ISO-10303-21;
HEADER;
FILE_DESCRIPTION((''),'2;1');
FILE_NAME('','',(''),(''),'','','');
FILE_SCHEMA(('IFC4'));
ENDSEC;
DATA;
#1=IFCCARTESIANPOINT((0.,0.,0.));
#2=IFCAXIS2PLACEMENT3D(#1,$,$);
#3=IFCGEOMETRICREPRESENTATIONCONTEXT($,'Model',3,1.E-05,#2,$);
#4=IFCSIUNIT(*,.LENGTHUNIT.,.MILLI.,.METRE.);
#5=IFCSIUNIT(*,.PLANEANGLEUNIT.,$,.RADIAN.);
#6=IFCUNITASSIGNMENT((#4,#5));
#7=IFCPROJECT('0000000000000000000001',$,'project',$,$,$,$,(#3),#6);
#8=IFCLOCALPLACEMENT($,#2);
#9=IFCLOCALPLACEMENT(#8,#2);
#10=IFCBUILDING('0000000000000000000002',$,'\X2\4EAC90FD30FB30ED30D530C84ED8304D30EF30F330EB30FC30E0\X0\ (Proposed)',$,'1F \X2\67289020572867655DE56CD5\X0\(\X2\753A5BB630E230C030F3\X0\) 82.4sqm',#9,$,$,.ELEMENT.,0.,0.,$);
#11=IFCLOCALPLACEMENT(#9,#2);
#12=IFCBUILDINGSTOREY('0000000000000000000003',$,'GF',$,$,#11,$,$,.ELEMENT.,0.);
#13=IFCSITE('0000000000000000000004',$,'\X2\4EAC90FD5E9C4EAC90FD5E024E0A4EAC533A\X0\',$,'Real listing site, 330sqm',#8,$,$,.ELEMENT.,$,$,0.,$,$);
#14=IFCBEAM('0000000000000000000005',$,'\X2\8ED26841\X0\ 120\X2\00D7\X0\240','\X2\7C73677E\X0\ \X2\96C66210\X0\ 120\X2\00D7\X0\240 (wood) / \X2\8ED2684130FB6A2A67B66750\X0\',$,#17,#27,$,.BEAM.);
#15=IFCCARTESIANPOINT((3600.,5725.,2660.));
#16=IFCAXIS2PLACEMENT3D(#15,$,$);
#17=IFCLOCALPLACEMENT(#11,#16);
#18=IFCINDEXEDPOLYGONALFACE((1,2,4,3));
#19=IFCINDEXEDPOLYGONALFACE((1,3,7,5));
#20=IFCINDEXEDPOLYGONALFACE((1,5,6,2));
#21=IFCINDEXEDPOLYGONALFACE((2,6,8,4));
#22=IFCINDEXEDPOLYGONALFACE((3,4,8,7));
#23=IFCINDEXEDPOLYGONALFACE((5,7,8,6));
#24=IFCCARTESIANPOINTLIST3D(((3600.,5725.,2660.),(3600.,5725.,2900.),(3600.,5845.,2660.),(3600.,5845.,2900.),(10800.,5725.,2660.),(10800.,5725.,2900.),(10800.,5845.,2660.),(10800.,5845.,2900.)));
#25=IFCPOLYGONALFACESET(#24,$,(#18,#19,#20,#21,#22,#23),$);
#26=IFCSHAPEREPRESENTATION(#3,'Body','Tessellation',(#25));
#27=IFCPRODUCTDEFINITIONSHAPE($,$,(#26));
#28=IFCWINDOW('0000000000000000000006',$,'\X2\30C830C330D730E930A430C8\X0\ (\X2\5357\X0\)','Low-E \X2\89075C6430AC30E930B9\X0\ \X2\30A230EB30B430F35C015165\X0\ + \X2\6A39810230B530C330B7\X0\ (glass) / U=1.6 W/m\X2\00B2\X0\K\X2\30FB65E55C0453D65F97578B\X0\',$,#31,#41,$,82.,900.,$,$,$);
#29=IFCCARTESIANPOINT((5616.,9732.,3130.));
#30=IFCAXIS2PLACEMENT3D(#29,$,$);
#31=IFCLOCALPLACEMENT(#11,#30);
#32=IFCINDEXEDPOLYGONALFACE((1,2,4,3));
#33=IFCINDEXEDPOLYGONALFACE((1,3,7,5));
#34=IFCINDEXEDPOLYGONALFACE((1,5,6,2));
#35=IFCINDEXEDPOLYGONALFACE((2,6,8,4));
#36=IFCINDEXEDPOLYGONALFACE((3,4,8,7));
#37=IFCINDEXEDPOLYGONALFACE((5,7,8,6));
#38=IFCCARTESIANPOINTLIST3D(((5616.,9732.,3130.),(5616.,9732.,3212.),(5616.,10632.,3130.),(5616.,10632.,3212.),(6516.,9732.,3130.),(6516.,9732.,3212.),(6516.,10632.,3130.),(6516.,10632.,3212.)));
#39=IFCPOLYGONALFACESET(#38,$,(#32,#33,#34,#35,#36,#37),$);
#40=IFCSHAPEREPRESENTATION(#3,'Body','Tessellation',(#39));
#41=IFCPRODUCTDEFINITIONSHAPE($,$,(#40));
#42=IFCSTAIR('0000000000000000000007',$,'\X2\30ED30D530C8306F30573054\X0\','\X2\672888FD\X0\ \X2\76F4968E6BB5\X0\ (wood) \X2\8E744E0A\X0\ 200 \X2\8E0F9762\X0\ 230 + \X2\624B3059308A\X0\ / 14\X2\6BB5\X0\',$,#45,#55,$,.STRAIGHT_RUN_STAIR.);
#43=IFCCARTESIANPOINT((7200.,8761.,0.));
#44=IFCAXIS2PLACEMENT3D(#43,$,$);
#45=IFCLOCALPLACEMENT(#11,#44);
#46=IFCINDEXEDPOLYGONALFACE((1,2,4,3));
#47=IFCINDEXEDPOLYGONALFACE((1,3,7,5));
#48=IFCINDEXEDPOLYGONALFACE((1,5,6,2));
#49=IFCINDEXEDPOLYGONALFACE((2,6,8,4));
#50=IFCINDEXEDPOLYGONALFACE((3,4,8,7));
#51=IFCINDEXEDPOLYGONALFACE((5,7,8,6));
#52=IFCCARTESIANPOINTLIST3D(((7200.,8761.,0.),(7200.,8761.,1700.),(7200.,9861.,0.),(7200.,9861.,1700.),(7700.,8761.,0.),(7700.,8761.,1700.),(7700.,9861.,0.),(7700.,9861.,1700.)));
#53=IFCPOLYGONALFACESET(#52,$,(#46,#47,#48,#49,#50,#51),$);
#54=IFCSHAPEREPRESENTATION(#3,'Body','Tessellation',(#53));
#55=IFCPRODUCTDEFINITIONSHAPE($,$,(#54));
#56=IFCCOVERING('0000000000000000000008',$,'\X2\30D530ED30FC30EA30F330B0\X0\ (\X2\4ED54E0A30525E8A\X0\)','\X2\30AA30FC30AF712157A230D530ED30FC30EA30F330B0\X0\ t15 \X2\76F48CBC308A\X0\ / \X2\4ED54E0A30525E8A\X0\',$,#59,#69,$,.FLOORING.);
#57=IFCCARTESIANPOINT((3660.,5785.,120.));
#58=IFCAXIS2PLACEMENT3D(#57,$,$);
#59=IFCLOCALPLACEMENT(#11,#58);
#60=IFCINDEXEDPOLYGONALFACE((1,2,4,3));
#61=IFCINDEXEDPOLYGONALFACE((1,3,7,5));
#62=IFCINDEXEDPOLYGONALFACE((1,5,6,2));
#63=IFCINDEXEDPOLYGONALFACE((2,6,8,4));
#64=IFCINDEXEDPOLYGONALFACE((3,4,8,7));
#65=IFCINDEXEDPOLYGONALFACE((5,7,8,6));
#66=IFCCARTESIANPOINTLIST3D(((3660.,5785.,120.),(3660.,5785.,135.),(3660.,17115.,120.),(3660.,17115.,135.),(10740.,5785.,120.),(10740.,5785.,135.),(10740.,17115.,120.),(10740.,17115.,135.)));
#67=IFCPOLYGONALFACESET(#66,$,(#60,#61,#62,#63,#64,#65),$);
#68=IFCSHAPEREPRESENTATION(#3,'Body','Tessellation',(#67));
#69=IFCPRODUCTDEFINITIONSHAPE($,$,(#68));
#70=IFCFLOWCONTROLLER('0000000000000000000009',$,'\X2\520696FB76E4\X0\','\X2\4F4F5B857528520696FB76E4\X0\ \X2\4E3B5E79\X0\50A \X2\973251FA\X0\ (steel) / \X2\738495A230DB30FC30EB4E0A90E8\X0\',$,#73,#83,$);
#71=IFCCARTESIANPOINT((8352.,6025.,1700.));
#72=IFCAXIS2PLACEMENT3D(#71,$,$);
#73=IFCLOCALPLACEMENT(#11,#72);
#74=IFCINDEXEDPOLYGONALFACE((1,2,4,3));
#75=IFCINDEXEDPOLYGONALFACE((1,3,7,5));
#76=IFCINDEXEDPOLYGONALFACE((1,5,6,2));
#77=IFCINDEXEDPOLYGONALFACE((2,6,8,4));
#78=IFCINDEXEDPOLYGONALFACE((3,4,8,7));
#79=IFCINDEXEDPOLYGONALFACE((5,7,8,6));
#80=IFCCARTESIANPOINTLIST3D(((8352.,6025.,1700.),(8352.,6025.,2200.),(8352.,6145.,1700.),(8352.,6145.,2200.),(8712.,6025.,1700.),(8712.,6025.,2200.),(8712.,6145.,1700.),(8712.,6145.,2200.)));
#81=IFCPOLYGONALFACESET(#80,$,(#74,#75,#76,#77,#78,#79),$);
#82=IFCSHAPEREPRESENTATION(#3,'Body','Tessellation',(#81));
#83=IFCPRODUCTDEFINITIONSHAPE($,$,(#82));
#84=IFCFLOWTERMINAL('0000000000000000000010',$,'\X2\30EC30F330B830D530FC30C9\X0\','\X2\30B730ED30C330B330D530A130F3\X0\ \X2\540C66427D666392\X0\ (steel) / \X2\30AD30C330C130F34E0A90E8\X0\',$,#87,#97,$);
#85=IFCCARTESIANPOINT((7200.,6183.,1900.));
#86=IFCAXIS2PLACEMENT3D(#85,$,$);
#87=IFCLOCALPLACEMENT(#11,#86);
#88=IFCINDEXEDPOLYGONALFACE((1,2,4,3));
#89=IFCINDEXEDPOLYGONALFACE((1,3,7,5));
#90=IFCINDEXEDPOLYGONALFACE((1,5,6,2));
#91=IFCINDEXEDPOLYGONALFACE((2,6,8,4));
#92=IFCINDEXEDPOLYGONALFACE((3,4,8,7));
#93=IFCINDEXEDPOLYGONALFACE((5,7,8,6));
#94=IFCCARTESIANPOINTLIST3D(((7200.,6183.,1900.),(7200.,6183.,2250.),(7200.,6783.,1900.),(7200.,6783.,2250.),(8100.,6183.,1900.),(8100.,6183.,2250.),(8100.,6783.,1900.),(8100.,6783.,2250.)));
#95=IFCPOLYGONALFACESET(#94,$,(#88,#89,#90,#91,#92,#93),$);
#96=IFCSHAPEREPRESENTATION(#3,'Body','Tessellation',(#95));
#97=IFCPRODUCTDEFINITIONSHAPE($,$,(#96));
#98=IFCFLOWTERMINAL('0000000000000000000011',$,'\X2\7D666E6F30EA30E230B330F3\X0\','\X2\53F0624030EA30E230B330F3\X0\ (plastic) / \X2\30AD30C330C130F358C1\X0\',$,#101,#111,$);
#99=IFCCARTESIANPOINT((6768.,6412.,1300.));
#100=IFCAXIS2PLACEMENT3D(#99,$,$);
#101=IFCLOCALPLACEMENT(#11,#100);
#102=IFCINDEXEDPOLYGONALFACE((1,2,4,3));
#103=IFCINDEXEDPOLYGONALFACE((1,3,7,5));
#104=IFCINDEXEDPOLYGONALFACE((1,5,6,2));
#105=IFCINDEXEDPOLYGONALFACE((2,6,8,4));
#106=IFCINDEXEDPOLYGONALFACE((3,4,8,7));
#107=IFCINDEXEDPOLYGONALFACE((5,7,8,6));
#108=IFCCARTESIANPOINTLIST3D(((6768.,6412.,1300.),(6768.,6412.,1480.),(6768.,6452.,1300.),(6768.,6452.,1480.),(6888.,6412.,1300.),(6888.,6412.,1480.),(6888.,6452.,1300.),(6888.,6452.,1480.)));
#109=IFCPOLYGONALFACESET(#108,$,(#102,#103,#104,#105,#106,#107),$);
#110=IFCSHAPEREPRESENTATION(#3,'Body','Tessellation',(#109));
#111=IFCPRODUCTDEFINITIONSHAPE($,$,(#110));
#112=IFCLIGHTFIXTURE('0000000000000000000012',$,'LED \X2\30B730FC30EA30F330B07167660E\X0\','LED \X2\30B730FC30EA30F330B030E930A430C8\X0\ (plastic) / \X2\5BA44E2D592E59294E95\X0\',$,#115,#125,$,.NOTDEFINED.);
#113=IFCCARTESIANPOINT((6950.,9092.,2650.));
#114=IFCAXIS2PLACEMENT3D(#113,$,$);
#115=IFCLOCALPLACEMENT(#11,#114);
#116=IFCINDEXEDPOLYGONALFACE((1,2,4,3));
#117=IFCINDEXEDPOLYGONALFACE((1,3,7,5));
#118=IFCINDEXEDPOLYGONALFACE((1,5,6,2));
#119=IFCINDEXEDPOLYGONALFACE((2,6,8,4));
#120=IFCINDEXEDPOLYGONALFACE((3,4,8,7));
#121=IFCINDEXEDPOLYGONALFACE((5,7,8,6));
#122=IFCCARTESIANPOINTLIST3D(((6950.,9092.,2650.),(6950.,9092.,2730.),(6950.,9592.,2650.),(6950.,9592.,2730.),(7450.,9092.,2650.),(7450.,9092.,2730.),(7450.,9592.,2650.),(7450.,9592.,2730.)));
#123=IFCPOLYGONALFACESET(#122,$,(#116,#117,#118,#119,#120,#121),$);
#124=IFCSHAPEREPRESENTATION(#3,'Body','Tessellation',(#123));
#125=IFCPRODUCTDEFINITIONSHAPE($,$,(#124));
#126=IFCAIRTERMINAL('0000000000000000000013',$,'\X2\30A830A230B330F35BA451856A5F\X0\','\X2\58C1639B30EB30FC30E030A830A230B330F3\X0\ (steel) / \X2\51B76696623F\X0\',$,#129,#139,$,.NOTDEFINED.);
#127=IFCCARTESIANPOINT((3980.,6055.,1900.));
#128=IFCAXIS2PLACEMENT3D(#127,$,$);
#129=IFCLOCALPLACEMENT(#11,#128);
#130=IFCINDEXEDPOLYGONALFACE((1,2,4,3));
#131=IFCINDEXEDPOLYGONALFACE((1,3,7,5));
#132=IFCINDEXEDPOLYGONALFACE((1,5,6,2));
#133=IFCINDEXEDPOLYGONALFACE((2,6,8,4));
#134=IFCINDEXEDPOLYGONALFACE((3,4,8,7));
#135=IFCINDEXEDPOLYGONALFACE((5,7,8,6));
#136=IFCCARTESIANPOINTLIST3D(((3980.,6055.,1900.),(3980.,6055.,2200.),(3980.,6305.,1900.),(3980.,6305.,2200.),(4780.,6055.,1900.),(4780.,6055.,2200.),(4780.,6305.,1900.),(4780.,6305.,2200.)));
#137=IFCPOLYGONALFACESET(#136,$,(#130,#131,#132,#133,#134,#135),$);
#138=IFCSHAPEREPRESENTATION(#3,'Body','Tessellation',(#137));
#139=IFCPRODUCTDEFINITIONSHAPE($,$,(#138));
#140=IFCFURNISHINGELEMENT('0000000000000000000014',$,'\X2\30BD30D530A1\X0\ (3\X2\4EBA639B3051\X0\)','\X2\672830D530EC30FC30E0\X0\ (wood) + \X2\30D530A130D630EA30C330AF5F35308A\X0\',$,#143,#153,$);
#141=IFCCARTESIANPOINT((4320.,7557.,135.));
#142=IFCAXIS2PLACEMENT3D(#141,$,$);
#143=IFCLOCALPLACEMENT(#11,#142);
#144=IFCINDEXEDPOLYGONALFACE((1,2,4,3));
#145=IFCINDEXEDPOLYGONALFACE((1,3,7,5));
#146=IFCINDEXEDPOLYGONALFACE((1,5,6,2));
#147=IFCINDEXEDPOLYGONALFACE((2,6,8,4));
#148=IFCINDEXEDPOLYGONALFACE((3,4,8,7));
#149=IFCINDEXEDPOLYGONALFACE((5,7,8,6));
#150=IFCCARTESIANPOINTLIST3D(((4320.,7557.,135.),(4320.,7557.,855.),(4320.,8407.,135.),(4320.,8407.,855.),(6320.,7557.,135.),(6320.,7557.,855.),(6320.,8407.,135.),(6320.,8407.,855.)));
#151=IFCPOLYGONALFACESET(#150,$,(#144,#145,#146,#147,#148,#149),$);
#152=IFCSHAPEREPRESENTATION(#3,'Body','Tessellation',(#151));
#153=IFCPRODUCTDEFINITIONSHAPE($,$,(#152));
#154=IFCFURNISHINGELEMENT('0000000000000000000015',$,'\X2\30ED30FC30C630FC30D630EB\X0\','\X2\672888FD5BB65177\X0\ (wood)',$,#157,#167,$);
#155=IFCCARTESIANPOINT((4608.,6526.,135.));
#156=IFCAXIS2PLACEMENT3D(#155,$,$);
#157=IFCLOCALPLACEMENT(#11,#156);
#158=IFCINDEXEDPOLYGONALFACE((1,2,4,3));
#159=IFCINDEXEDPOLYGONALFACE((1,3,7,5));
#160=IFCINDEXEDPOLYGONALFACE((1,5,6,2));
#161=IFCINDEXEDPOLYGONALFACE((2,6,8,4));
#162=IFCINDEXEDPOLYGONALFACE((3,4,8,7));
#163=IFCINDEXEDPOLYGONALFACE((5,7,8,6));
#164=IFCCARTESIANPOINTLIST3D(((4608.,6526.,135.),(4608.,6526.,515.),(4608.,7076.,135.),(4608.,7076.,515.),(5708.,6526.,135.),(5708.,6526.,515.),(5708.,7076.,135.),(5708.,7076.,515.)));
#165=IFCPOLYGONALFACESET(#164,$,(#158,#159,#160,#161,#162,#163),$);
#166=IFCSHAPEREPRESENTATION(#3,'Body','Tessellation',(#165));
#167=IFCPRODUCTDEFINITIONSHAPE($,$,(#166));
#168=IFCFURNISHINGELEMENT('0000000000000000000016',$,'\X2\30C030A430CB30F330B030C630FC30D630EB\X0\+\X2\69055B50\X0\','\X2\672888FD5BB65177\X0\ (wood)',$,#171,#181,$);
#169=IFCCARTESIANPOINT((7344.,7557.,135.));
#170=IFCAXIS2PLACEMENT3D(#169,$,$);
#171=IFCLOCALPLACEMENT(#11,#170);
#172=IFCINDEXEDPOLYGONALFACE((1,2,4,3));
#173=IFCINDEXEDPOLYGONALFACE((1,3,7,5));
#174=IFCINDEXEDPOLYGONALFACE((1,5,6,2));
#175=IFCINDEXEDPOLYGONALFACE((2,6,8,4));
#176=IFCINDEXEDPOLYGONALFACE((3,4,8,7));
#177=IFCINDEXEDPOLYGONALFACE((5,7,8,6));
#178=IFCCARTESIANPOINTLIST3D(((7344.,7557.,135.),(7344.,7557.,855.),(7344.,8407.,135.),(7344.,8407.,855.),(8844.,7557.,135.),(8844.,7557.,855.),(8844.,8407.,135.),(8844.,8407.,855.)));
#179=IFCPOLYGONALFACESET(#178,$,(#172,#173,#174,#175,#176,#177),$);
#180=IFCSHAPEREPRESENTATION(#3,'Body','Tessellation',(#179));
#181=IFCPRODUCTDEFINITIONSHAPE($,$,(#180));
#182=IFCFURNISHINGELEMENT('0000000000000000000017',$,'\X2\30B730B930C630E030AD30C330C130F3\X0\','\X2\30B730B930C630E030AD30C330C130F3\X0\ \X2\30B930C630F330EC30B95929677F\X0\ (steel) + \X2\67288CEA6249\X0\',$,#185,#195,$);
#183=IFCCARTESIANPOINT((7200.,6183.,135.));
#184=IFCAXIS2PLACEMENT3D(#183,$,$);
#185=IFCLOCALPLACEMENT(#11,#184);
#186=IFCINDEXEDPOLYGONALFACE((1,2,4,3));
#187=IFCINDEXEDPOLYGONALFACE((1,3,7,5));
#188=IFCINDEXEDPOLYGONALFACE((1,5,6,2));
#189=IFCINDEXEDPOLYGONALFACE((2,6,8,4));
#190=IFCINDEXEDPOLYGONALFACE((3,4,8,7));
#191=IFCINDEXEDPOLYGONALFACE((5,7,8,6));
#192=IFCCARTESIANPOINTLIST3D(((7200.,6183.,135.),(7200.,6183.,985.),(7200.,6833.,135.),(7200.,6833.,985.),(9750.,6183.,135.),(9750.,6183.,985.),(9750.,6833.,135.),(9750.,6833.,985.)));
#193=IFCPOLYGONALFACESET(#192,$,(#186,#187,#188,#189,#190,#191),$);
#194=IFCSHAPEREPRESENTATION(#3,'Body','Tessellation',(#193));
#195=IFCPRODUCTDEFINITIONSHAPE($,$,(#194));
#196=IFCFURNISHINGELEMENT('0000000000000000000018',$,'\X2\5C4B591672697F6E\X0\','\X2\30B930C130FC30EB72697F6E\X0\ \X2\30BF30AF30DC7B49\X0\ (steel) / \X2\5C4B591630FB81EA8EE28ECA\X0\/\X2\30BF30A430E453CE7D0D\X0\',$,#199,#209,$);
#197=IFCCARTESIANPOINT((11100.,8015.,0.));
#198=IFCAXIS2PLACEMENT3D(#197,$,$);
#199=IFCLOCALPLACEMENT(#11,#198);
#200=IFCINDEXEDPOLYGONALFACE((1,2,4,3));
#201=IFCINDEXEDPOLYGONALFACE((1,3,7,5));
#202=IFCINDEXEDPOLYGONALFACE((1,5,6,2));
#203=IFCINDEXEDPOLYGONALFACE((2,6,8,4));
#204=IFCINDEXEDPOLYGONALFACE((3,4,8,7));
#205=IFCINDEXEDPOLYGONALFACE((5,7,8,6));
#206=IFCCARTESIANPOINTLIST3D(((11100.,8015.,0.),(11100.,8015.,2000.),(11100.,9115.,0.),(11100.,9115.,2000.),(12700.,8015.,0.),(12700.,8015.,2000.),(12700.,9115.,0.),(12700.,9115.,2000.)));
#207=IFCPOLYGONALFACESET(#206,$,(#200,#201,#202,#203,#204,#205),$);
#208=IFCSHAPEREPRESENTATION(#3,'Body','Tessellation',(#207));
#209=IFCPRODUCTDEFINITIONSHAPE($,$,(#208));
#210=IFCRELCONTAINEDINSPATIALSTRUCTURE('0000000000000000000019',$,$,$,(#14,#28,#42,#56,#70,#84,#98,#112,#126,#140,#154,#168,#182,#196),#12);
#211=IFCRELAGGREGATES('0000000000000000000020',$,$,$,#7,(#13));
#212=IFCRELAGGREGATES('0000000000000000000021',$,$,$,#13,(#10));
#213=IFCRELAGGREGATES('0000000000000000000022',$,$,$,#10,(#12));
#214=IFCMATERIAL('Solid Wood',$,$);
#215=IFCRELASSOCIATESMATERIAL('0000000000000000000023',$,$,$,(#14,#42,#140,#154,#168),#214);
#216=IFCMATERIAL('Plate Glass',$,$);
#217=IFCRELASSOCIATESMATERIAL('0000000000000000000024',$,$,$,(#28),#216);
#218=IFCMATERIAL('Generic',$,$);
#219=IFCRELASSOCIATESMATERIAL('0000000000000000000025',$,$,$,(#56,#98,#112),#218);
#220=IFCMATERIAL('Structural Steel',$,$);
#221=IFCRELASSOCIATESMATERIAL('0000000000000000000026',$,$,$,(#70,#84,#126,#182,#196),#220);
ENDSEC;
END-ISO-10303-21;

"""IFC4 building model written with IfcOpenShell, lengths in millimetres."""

from ifc_helpers import new_model, si_unit, frame, frame_2d, origin, place, context, project, spatial, rectangle, extrude, material, element, save


model = new_model("IFC4")

# Units and contexts
model_context = context("Model", 3, precision=1e-05, world=origin())
ifc_project = project(units=[si_unit("LENGTHUNIT", "METRE", prefix="MILLI"), si_unit("PLANEANGLEUNIT", "RADIAN")], contexts=[model_context])

# Site, building, storey
site_placement = place(None, origin())
site = spatial("IfcSite", under=ifc_project, at=site_placement, Name="京都府京都市上京区", ObjectType="Real listing site, 330sqm", CompositionType="ELEMENT", RefElevation=0.0)
building_placement = place(site_placement, origin())
building = spatial("IfcBuilding", under=site, at=building_placement, Name="京都・ロフト付きワンルーム (Proposed)", ObjectType="1F 木造在来工法(町家モダン) 82.4sqm", CompositionType="ELEMENT", ElevationOfRefHeight=0.0, ElevationOfTerrain=0.0)
storey_placement = place(building_placement, origin())
storey = spatial("IfcBuildingStorey", under=building, at=storey_placement, Name="GF", CompositionType="ELEMENT", Elevation=0.0)

# Shared definitions
ifc_material_1 = material(Name="Solid Wood")

# Beam
beam_1_placement = place(storey_placement, frame((3600.0, 5725.0, 2660.0)))
element("IfcBeam", 1, at=beam_1_placement, inside=storey, material=ifc_material_1, Name="軒桁 120×240", Description="米松 集成 120×240 (wood) / 軒桁・横架材", PredefinedType="BEAM", context=model_context, shape_type="SweptSolid", body=[
    extrude(rectangle(XDim=7200.0, YDim=120.0, at=frame_2d((3600.0, 60.0))), frame((3600.0, 5725.0, 2660.0)), (0.0, 0.0, 1.0), 240.0),
])

# Window
ifc_material_2 = material(Name="Plate Glass")
window_placement = place(storey_placement, frame((5616.0, 9732.0, 3130.0)))
element("IfcWindow", 2, at=window_placement, inside=storey, material=ifc_material_2, Name="トップライト (南)", Description="Low-E 複層ガラス アルゴン封入 + 樹脂サッシ (glass) / U=1.6 W/m²K・日射取得型", OverallHeight=82.0, OverallWidth=900.0, context=model_context, shape_type="SweptSolid", body=[
    extrude(rectangle(XDim=900.0, YDim=900.0, at=frame_2d((450.0, 450.0))), frame((5616.0, 9732.0, 3130.0)), (0.0, 0.0, 1.0), 82.0),
])

# Stair
stair_placement = place(storey_placement, frame((7200.0, 8761.0, 0.0)))
element("IfcStair", 3, at=stair_placement, inside=storey, material=ifc_material_1, Name="ロフトはしご", Description="木製 直階段 (wood) 蹴上 200 踏面 230 + 手すり / 14段", PredefinedType="STRAIGHT_RUN_STAIR", context=model_context, shape_type="SweptSolid", body=[
    extrude(rectangle(XDim=500.0, YDim=1100.0, at=frame_2d((250.0, 550.0))), frame((7200.0, 8761.0, 0.0)), (0.0, 0.0, 1.0), 1700.0),
])

# Covering
ifc_material_3 = material(Name="Generic")
covering_placement = place(storey_placement, frame((3660.0, 5785.0, 120.0)))
element("IfcCovering", 4, at=covering_placement, inside=storey, material=ifc_material_3, Name="フローリング (仕上げ床)", Description="オーク無垢フローリング t15 直貼り / 仕上げ床", PredefinedType="FLOORING", context=model_context, shape_type="SweptSolid", body=[
    extrude(rectangle(XDim=7080.0, YDim=11330.0, at=frame_2d((3540.0, 5665.0))), frame((3660.0, 5785.0, 120.0)), (0.0, 0.0, 1.0), 15.0),
])

# Flow controller
ifc_material_4 = material(Name="Structural Steel")
flow_controller_placement = place(storey_placement, frame((8352.0, 6025.0, 1700.0)))
element("IfcFlowController", 5, at=flow_controller_placement, inside=storey, material=ifc_material_4, Name="分電盤", Description="住宅用分電盤 主幹50A 露出 (steel) / 玄関ホール上部", context=model_context, shape_type="SweptSolid", body=[
    extrude(rectangle(XDim=360.0, YDim=120.0, at=frame_2d((180.0, 60.0))), frame((8352.0, 6025.0, 1700.0)), (0.0, 0.0, 1.0), 500.0),
])

# Flow terminals
flow_terminal_1_placement = place(storey_placement, frame((7200.0, 6183.0, 1900.0)))
element("IfcFlowTerminal", 6, at=flow_terminal_1_placement, inside=storey, material=ifc_material_4, Name="レンジフード", Description="シロッコファン 同時給排 (steel) / キッチン上部", context=model_context, shape_type="SweptSolid", body=[
    extrude(rectangle(XDim=900.0, YDim=600.0, at=frame_2d((450.0, 300.0))), frame((7200.0, 6183.0, 1900.0)), (0.0, 0.0, 1.0), 350.0),
])
flow_terminal_2_placement = place(storey_placement, frame((6768.0, 6412.0, 1300.0)))
element("IfcFlowTerminal", 7, at=flow_terminal_2_placement, inside=storey, material=ifc_material_3, Name="給湯リモコン", Description="台所リモコン (plastic) / キッチン壁", context=model_context, shape_type="SweptSolid", body=[
    extrude(rectangle(XDim=120.0, YDim=40.0, at=frame_2d((60.0, 20.0))), frame((6768.0, 6412.0, 1300.0)), (0.0, 0.0, 1.0), 180.0),
])

# Light fixture
light_fixture_placement = place(storey_placement, frame((6950.0, 9092.0, 2650.0)))
element("IfcLightFixture", 8, at=light_fixture_placement, inside=storey, material=ifc_material_3, Name="LED シーリング照明", Description="LED シーリングライト (plastic) / 室中央天井", PredefinedType="NOTDEFINED", context=model_context, shape_type="SweptSolid", body=[
    extrude(rectangle(XDim=500.0, YDim=500.0, at=frame_2d((250.0, 250.0))), frame((6950.0, 9092.0, 2650.0)), (0.0, 0.0, 1.0), 80.0),
])

# Air terminal
air_terminal_placement = place(storey_placement, frame((3980.0, 6055.0, 1900.0)))
element("IfcAirTerminal", 9, at=air_terminal_placement, inside=storey, material=ifc_material_4, Name="エアコン室内機", Description="壁掛ルームエアコン (steel) / 冷暖房", PredefinedType="NOTDEFINED", context=model_context, shape_type="SweptSolid", body=[
    extrude(rectangle(XDim=800.0, YDim=250.0, at=frame_2d((400.0, 125.0))), frame((3980.0, 6055.0, 1900.0)), (0.0, 0.0, 1.0), 300.0),
])

# Furnishing elements
furnishing_1_placement = place(storey_placement, frame((4320.0, 7557.0, 135.0)))
element("IfcFurnishingElement", 10, at=furnishing_1_placement, inside=storey, material=ifc_material_1, Name="ソファ (3人掛け)", Description="木フレーム (wood) + ファブリック張り", context=model_context, shape_type="SweptSolid", body=[
    extrude(rectangle(XDim=2000.0, YDim=850.0, at=frame_2d((1000.0, 425.0))), frame((4320.0, 7557.0, 135.0)), (0.0, 0.0, 1.0), 720.0),
])
furnishing_2_placement = place(storey_placement, frame((4608.0, 6526.0, 135.0)))
element("IfcFurnishingElement", 11, at=furnishing_2_placement, inside=storey, material=ifc_material_1, Name="ローテーブル", Description="木製家具 (wood)", context=model_context, shape_type="SweptSolid", body=[
    extrude(rectangle(XDim=1100.0, YDim=550.0, at=frame_2d((550.0, 275.0))), frame((4608.0, 6526.0, 135.0)), (0.0, 0.0, 1.0), 380.0),
])
furnishing_3_placement = place(storey_placement, frame((7344.0, 7557.0, 135.0)))
element("IfcFurnishingElement", 12, at=furnishing_3_placement, inside=storey, material=ifc_material_1, Name="ダイニングテーブル+椅子", Description="木製家具 (wood)", context=model_context, shape_type="SweptSolid", body=[
    extrude(rectangle(XDim=1500.0, YDim=850.0, at=frame_2d((750.0, 425.0))), frame((7344.0, 7557.0, 135.0)), (0.0, 0.0, 1.0), 720.0),
])
furnishing_4_placement = place(storey_placement, frame((7200.0, 6183.0, 135.0)))
element("IfcFurnishingElement", 13, at=furnishing_4_placement, inside=storey, material=ifc_material_4, Name="システムキッチン", Description="システムキッチン ステンレス天板 (steel) + 木質扉", context=model_context, shape_type="SweptSolid", body=[
    extrude(rectangle(XDim=2550.0, YDim=650.0, at=frame_2d((1275.0, 325.0))), frame((7200.0, 6183.0, 135.0)), (0.0, 0.0, 1.0), 850.0),
])
furnishing_5_placement = place(storey_placement, frame((11100.0, 8015.0, 0.0)))
element("IfcFurnishingElement", 14, at=furnishing_5_placement, inside=storey, material=ifc_material_4, Name="屋外物置", Description="スチール物置 タクボ等 (steel) / 屋外・自転車/タイヤ収納", context=model_context, shape_type="SweptSolid", body=[
    extrude(rectangle(XDim=1600.0, YDim=1100.0, at=frame_2d((800.0, 550.0))), frame((11100.0, 8015.0, 0.0)), (0.0, 0.0, 1.0), 2000.0),
])

save(model, "model.ifc")
